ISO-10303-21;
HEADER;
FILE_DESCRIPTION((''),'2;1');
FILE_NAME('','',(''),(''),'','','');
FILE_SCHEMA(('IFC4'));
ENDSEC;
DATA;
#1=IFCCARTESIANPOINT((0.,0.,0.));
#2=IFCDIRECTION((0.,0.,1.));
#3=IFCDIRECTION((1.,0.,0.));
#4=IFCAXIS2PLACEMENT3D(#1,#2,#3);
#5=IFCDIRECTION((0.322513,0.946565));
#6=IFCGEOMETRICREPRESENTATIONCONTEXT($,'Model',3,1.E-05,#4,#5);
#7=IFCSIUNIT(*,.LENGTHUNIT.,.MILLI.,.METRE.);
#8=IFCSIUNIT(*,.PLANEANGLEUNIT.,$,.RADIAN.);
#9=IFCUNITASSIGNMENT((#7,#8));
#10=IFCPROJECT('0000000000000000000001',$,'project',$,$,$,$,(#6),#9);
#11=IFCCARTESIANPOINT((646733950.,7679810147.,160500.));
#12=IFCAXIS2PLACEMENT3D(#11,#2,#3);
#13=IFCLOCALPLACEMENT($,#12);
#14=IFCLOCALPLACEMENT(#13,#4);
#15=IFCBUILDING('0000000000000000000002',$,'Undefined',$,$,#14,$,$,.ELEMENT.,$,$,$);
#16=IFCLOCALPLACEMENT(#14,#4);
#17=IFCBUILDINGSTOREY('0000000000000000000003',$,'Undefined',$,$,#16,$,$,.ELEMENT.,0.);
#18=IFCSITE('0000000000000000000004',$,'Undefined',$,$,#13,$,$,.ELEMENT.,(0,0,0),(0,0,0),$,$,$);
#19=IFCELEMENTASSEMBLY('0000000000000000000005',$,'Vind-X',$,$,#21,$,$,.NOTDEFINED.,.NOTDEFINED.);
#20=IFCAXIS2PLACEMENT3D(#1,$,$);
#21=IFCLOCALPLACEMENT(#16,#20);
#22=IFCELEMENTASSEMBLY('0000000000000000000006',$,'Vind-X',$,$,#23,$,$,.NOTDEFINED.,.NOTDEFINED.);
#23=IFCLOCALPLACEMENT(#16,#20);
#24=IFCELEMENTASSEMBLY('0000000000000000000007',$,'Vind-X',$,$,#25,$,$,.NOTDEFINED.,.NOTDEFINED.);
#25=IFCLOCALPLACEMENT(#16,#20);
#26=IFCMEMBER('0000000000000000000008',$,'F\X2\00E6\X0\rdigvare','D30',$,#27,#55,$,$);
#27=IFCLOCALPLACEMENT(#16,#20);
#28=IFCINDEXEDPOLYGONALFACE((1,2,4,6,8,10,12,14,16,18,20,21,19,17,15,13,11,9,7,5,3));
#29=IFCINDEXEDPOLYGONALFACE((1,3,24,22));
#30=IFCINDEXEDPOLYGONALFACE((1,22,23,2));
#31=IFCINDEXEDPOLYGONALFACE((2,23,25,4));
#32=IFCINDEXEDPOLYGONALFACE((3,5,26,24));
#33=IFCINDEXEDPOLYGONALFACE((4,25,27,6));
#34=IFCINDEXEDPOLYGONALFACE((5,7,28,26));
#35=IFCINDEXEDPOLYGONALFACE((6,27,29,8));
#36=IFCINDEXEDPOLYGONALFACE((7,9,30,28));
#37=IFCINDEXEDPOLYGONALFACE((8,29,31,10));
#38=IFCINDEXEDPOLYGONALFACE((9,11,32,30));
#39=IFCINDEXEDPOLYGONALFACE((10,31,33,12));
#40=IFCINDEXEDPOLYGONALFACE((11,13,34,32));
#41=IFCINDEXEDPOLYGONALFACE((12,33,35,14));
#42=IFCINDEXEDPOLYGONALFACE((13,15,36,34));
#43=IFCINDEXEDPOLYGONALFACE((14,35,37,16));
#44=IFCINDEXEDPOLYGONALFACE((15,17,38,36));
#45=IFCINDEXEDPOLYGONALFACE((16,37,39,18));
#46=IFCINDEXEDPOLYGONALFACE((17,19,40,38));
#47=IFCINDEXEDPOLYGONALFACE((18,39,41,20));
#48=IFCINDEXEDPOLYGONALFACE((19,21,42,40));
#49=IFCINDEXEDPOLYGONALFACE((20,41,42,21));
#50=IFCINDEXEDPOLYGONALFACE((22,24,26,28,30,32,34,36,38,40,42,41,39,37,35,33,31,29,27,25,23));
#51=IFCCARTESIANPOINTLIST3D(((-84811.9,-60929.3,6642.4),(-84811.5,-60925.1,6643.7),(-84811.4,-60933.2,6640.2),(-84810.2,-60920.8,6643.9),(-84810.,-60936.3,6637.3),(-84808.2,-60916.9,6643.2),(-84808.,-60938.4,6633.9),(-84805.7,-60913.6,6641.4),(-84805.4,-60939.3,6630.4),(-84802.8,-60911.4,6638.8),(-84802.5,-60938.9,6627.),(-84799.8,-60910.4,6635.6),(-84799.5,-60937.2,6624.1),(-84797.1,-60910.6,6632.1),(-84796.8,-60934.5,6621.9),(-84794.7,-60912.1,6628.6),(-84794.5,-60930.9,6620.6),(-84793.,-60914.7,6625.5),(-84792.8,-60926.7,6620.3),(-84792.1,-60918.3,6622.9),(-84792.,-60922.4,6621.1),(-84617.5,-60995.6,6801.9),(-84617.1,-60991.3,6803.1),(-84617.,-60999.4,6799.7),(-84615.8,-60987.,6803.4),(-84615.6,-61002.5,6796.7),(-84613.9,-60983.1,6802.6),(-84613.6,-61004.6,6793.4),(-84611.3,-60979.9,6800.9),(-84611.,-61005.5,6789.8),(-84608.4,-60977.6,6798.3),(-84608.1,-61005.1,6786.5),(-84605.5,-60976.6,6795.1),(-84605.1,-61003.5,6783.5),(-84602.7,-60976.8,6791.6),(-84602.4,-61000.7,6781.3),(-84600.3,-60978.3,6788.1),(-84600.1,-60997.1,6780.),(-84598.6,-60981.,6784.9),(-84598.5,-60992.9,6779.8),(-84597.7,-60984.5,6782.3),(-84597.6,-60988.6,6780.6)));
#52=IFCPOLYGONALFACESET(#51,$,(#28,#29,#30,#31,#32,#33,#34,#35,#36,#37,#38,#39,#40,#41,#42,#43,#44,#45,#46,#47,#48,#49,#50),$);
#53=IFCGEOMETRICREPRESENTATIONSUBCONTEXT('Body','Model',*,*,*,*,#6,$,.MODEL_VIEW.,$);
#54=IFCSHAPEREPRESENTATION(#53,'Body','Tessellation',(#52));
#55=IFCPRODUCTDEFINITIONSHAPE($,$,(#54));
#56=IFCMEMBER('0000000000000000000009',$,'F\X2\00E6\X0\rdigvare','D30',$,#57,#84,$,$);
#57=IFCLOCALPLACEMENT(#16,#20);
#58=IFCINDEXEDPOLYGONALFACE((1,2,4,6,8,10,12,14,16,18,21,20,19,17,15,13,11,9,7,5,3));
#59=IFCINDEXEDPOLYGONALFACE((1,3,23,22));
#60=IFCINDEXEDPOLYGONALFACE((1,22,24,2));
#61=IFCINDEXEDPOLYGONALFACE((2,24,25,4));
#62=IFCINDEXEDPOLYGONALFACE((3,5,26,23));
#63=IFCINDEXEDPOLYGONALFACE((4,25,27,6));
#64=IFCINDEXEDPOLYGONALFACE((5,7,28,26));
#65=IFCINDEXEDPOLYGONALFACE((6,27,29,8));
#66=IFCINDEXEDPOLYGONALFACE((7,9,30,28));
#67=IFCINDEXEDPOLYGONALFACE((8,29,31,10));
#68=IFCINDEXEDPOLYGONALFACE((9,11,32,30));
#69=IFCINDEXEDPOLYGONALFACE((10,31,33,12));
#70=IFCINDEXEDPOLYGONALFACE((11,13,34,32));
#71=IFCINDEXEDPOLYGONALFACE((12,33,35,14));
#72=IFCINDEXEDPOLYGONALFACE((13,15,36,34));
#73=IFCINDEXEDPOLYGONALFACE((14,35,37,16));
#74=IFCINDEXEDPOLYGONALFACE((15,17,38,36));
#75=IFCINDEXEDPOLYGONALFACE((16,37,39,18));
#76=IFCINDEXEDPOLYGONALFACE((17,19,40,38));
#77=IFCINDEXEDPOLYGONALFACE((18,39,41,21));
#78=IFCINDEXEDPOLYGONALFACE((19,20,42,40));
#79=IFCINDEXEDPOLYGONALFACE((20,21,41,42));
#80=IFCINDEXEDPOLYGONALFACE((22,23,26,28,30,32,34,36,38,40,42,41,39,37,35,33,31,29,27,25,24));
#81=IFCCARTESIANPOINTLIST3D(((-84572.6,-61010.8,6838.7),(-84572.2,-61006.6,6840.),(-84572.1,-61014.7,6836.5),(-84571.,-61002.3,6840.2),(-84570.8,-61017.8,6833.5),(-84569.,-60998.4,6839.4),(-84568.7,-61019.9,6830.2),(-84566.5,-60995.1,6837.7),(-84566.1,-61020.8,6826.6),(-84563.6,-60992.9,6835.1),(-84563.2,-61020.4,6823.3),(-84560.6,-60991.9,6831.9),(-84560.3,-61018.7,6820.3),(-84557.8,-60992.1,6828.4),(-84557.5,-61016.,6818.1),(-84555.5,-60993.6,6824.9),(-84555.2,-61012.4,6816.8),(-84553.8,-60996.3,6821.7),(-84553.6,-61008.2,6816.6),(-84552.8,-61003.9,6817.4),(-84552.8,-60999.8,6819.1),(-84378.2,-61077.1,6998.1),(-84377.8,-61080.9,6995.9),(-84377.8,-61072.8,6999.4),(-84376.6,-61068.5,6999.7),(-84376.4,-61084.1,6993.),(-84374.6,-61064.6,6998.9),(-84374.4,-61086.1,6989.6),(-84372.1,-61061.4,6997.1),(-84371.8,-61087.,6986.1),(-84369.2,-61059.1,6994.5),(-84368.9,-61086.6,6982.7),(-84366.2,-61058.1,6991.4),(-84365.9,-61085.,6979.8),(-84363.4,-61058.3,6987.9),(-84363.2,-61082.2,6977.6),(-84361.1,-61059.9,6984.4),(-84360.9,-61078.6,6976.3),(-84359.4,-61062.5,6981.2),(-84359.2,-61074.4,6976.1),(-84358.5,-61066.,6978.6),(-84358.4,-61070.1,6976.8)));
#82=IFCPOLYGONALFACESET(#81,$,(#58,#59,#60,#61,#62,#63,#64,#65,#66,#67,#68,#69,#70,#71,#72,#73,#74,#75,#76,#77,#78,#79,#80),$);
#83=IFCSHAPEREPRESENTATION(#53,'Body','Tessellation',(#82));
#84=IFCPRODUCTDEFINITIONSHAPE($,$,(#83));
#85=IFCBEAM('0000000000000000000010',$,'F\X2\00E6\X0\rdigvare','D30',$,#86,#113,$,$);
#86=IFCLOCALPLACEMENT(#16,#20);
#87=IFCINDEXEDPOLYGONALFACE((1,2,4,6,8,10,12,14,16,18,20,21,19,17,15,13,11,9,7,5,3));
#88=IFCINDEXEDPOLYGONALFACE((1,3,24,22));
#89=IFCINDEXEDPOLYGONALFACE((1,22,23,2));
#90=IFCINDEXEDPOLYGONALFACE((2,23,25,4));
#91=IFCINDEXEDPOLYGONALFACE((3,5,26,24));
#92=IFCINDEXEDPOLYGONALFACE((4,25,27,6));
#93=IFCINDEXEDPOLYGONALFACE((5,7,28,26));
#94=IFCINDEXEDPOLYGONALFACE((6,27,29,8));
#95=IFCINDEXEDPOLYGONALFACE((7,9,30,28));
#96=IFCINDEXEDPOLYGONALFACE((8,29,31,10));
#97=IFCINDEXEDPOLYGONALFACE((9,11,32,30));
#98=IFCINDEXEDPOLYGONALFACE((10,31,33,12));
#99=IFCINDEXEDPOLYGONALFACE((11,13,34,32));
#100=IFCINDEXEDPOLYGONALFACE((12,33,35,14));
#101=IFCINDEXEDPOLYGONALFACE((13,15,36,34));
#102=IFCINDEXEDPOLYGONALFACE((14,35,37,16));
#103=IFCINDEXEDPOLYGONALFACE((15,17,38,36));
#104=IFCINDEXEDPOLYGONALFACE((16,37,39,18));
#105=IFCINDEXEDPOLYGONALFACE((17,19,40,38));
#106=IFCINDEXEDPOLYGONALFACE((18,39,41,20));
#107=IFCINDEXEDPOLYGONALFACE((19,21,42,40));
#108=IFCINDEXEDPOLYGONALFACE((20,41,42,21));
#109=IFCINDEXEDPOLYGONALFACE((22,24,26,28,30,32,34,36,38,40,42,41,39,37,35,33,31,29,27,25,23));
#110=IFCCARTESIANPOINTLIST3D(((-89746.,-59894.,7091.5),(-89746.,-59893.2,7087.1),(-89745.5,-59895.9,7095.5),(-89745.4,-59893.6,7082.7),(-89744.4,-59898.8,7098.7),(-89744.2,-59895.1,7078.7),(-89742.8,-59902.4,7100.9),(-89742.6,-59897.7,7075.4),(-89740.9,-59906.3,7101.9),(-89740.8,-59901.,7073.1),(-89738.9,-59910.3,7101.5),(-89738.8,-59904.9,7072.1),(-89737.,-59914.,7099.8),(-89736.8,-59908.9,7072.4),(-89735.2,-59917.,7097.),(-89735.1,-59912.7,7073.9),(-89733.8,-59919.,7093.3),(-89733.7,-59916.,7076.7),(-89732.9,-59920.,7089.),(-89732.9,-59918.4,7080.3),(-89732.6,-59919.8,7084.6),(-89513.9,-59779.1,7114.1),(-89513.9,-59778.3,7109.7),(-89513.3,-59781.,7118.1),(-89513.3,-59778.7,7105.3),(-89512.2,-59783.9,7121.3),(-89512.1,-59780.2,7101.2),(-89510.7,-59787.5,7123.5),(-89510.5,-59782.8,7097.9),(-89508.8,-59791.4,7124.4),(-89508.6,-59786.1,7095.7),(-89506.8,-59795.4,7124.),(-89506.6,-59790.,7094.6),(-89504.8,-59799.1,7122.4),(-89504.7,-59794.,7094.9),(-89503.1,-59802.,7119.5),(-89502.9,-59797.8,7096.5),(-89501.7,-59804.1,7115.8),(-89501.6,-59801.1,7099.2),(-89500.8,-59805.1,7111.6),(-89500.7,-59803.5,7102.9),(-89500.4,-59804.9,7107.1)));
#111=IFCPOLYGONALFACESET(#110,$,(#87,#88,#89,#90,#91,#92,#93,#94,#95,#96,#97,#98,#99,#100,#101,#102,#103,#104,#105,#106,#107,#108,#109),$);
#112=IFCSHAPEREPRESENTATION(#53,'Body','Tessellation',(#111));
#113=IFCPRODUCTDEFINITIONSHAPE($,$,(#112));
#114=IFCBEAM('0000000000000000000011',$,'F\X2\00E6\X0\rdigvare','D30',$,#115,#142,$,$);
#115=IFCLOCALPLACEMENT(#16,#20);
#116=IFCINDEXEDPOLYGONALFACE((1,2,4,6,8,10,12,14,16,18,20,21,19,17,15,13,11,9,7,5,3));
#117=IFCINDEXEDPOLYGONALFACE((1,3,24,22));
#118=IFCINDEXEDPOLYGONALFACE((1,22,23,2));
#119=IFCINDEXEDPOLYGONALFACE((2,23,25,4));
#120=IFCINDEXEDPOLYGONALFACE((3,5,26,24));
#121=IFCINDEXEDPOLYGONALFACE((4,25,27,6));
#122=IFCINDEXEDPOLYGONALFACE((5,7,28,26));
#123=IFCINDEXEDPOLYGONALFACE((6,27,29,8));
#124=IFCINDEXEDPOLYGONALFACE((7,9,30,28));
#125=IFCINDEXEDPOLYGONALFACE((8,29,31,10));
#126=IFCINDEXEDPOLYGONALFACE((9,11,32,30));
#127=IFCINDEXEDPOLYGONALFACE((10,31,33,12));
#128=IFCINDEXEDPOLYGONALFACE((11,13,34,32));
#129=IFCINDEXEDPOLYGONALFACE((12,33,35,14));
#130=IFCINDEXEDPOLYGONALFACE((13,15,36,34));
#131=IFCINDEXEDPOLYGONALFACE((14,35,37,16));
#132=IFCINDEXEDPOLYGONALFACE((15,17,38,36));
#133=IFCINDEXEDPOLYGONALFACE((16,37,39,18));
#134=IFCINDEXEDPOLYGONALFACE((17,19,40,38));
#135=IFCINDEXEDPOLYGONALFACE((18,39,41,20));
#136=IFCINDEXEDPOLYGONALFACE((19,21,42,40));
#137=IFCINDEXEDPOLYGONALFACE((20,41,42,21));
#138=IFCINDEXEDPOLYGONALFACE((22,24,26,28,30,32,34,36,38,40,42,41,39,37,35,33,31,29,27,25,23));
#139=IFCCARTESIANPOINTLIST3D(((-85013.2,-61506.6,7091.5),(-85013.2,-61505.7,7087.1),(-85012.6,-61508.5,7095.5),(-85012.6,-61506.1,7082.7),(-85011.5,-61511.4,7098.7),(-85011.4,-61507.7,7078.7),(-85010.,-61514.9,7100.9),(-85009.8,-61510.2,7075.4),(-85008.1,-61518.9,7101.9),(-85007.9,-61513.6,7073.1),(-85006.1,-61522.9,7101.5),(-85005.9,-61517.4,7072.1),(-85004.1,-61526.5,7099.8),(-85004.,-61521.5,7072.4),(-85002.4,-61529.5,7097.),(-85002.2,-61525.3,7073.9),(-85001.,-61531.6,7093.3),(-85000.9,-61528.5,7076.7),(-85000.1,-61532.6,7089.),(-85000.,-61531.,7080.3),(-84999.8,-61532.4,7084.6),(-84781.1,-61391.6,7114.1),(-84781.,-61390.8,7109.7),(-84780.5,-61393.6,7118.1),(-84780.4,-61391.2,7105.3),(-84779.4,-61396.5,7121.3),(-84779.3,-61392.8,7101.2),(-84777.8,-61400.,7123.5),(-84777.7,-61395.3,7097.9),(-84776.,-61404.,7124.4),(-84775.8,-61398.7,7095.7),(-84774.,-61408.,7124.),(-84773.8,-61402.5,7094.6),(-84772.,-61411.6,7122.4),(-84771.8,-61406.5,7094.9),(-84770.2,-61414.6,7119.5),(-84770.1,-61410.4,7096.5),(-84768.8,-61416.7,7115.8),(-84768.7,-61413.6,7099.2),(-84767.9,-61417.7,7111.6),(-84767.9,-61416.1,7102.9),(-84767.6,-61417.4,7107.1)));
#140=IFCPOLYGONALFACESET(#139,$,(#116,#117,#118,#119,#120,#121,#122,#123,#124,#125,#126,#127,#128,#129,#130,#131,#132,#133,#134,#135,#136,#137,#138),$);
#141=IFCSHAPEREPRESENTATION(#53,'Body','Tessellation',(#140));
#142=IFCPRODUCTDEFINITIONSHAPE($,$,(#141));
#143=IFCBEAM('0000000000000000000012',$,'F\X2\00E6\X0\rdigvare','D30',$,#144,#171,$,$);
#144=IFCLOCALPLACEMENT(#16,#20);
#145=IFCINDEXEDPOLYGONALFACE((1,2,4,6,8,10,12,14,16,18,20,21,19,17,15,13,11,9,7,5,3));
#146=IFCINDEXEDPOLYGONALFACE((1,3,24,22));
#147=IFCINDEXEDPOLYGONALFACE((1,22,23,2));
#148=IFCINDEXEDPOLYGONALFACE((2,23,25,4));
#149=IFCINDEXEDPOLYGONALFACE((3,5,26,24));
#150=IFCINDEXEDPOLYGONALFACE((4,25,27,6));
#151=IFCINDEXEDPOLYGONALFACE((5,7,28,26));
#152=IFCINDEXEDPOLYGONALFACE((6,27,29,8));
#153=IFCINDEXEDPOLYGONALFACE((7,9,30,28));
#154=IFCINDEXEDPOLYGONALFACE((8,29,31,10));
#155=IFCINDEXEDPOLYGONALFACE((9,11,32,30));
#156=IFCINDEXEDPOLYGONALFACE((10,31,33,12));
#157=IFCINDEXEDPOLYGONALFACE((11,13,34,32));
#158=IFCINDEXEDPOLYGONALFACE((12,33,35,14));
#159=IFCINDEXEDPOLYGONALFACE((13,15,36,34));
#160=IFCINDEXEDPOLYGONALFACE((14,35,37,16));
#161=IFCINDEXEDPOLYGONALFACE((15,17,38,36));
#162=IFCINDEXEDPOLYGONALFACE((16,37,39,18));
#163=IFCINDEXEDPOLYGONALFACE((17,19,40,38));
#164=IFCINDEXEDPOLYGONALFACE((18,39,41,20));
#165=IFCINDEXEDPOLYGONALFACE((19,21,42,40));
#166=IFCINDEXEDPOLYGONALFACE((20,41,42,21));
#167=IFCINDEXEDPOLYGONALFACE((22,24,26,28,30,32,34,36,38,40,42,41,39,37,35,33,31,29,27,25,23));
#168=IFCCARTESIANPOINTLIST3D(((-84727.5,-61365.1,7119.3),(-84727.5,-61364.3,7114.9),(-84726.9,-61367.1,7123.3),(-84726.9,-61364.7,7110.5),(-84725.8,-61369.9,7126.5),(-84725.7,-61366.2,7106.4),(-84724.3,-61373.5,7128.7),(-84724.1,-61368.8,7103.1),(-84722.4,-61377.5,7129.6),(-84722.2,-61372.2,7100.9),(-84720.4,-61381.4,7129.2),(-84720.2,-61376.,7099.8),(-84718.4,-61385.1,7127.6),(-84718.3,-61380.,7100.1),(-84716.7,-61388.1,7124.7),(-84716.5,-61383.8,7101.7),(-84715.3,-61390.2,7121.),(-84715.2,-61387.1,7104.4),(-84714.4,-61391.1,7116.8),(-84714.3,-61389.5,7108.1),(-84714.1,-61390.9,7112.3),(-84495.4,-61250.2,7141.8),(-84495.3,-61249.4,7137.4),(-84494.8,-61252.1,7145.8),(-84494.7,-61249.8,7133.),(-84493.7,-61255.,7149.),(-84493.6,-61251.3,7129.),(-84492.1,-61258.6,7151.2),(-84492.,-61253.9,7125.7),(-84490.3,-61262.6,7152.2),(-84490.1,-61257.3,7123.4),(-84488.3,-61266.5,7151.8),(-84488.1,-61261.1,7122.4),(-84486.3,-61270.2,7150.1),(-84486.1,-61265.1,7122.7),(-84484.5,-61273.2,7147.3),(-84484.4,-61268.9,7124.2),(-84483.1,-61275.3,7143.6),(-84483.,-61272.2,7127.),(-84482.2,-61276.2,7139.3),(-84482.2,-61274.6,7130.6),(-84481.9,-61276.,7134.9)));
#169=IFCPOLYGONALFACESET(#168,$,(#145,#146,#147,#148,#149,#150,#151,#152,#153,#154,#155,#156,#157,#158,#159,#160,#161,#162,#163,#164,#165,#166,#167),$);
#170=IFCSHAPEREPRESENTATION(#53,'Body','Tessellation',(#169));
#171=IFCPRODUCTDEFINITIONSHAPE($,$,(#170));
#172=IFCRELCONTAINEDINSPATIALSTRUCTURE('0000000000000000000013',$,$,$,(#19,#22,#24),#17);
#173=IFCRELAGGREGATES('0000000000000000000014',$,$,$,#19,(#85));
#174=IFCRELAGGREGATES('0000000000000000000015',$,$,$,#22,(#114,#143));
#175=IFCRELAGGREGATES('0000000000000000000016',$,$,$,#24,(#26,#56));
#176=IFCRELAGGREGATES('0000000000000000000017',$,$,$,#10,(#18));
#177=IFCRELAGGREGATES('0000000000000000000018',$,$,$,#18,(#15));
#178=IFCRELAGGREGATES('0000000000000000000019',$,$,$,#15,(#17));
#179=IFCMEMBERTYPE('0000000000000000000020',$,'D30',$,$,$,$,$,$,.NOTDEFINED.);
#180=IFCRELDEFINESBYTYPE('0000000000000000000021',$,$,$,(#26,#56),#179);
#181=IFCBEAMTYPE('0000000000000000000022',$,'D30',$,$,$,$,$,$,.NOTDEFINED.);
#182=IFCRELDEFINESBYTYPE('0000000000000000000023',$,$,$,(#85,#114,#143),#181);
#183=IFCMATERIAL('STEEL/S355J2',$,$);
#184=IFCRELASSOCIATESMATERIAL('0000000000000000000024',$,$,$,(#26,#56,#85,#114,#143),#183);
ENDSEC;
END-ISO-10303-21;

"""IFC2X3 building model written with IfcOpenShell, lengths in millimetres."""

from ifc_helpers import new_model, si_unit, direction, frame, origin_with_axes, origin_2d_with_axis, place, context, subcontext, project, spatial, circle, extrude, material, type_object, element, aggregate, save


model = new_model("IFC2X3")

# Units and contexts
model_context = context("Model", 3, precision=1e-05, world=origin_with_axes(), true_north=direction((0.322513, 0.946565)))
body_context = subcontext(model_context, "Body", "Model", "MODEL_VIEW")
ifc_project = project(units=[si_unit("LENGTHUNIT", "METRE", prefix="MILLI"), si_unit("PLANEANGLEUNIT", "RADIAN")], contexts=[model_context])

# Site, building, storey
site_placement = place(None, frame((646733950.0, 7679810147.0, 160500.0), z_axis=(0.0, 0.0, 1.0), x_axis=(1.0, 0.0, 0.0)))
site = spatial("IfcSite", under=ifc_project, at=site_placement, Name="Undefined", CompositionType="ELEMENT", RefLatitude=(0, 0, 0), RefLongitude=(0, 0, 0))
building_placement = place(site_placement, origin_with_axes())
building = spatial("IfcBuilding", under=site, at=building_placement, Name="Undefined", CompositionType="ELEMENT")
storey_placement = place(building_placement, origin_with_axes())
storey = spatial("IfcBuildingStorey", under=building, at=storey_placement, Name="Undefined", CompositionType="ELEMENT", Elevation=0.0)

# Element assemblies
assembly_1_placement = place(storey_placement, origin_with_axes())
assembly_1 = element("IfcElementAssembly", 1, at=assembly_1_placement, inside=storey, Name="Vind-X", AssemblyPlace="NOTDEFINED", PredefinedType="NOTDEFINED")
ifc_material_1 = material(Name="STEEL/S355J2")
assembly_2_placement = place(storey_placement, origin_with_axes())
assembly_2 = element("IfcElementAssembly", 2, at=assembly_2_placement, inside=storey, Name="Vind-X", AssemblyPlace="NOTDEFINED", PredefinedType="NOTDEFINED")

# Shared definitions
member_type_1 = type_object("IfcMemberType", Name="D30", PredefinedType="NOTDEFINED")

# Element assembly, members
assembly_3_placement = place(storey_placement, origin_with_axes())
assembly_3 = element("IfcElementAssembly", 3, at=assembly_3_placement, inside=storey, Name="Vind-X", AssemblyPlace="NOTDEFINED", PredefinedType="NOTDEFINED")
member_1_placement = place(assembly_3_placement, frame((-84607.5, -60991.0, 6791.6), z_axis=(-0.580574, 0.197813, 0.789813), x_axis=(-0.747609, 0.254725, -0.613348)))
member_1 = element("IfcMember", 4, at=member_1_placement, type_object=member_type_1, material=ifc_material_1, Name="Færdigvare", Description="D30", context=body_context, shape_type="SweptSolid", body=[
    extrude(circle(Radius=15.0, at=origin_2d_with_axis()), frame((260.0, 0.0, 0.0), z_axis=(-1.0, 0.0, 0.0), x_axis=(0.0, -1.0, 0.0)), (0.0, 0.0, 1.0), 260.0),
])
member_2_placement = place(assembly_3_placement, frame((-84368.3, -61072.5, 6987.9), z_axis=(-0.580575, 0.197813, 0.789812), x_axis=(-0.747608, 0.254725, -0.613349)))
member_2 = element("IfcMember", 5, at=member_2_placement, type_object=member_type_1, material=ifc_material_1, Name="Færdigvare", Description="D30", context=body_context, shape_type="SweptSolid", body=[
    extrude(circle(Radius=15.0, at=origin_2d_with_axis()), frame((260.0, 0.0, 0.0), z_axis=(-1.0, 0.0, 0.0), x_axis=(0.0, -1.0, 0.0)), (0.0, 0.0, 1.0), 260.0),
])

# Beams
beam_type_1 = type_object("IfcBeamType", Name="D30", PredefinedType="NOTDEFINED")
beam_1_placement = place(assembly_1_placement, frame((-89507.2, -59791.7, 7109.5), z_axis=(-0.448661, 0.889591, 0.085625), x_axis=(-0.892837, -0.441951, -0.086721)))
beam_1 = element("IfcBeam", 6, at=beam_1_placement, type_object=beam_type_1, material=ifc_material_1, Name="Færdigvare", Description="D30", context=body_context, shape_type="SweptSolid", body=[
    extrude(circle(Radius=15.0, at=origin_2d_with_axis()), frame((260.0, 0.0, 0.0), z_axis=(-1.0, 0.0, 0.0), x_axis=(0.0, -1.0, 0.0)), (0.0, 0.0, 1.0), 260.0),
])
aggregate(assembly_1, [beam_1])
beam_2_placement = place(assembly_2_placement, frame((-84774.4, -61404.3, 7109.5), z_axis=(-0.448661, 0.889591, 0.085625), x_axis=(-0.892837, -0.441951, -0.086721)))
beam_2 = element("IfcBeam", 7, at=beam_2_placement, type_object=beam_type_1, material=ifc_material_1, Name="Færdigvare", Description="D30", context=body_context, shape_type="SweptSolid", body=[
    extrude(circle(Radius=15.0, at=origin_2d_with_axis()), frame((260.0, 0.0, 0.0), z_axis=(-1.0, 0.0, 0.0), x_axis=(0.0, -1.0, 0.0)), (0.0, 0.0, 1.0), 260.0),
])
beam_3_placement = place(assembly_2_placement, frame((-84488.7, -61262.8, 7137.3), z_axis=(-0.448662, 0.88959, 0.085625), x_axis=(-0.892837, -0.441952, -0.086721)))
beam_3 = element("IfcBeam", 8, at=beam_3_placement, type_object=beam_type_1, material=ifc_material_1, Name="Færdigvare", Description="D30", context=body_context, shape_type="SweptSolid", body=[
    extrude(circle(Radius=15.0, at=origin_2d_with_axis()), frame((260.0, 0.0, 0.0), z_axis=(-1.0, 0.0, 0.0), x_axis=(0.0, -1.0, 0.0)), (0.0, 0.0, 1.0), 260.0),
])

aggregate(assembly_2, [beam_2, beam_3])
aggregate(assembly_3, [member_1, member_2])

save(model, "model.ifc")
